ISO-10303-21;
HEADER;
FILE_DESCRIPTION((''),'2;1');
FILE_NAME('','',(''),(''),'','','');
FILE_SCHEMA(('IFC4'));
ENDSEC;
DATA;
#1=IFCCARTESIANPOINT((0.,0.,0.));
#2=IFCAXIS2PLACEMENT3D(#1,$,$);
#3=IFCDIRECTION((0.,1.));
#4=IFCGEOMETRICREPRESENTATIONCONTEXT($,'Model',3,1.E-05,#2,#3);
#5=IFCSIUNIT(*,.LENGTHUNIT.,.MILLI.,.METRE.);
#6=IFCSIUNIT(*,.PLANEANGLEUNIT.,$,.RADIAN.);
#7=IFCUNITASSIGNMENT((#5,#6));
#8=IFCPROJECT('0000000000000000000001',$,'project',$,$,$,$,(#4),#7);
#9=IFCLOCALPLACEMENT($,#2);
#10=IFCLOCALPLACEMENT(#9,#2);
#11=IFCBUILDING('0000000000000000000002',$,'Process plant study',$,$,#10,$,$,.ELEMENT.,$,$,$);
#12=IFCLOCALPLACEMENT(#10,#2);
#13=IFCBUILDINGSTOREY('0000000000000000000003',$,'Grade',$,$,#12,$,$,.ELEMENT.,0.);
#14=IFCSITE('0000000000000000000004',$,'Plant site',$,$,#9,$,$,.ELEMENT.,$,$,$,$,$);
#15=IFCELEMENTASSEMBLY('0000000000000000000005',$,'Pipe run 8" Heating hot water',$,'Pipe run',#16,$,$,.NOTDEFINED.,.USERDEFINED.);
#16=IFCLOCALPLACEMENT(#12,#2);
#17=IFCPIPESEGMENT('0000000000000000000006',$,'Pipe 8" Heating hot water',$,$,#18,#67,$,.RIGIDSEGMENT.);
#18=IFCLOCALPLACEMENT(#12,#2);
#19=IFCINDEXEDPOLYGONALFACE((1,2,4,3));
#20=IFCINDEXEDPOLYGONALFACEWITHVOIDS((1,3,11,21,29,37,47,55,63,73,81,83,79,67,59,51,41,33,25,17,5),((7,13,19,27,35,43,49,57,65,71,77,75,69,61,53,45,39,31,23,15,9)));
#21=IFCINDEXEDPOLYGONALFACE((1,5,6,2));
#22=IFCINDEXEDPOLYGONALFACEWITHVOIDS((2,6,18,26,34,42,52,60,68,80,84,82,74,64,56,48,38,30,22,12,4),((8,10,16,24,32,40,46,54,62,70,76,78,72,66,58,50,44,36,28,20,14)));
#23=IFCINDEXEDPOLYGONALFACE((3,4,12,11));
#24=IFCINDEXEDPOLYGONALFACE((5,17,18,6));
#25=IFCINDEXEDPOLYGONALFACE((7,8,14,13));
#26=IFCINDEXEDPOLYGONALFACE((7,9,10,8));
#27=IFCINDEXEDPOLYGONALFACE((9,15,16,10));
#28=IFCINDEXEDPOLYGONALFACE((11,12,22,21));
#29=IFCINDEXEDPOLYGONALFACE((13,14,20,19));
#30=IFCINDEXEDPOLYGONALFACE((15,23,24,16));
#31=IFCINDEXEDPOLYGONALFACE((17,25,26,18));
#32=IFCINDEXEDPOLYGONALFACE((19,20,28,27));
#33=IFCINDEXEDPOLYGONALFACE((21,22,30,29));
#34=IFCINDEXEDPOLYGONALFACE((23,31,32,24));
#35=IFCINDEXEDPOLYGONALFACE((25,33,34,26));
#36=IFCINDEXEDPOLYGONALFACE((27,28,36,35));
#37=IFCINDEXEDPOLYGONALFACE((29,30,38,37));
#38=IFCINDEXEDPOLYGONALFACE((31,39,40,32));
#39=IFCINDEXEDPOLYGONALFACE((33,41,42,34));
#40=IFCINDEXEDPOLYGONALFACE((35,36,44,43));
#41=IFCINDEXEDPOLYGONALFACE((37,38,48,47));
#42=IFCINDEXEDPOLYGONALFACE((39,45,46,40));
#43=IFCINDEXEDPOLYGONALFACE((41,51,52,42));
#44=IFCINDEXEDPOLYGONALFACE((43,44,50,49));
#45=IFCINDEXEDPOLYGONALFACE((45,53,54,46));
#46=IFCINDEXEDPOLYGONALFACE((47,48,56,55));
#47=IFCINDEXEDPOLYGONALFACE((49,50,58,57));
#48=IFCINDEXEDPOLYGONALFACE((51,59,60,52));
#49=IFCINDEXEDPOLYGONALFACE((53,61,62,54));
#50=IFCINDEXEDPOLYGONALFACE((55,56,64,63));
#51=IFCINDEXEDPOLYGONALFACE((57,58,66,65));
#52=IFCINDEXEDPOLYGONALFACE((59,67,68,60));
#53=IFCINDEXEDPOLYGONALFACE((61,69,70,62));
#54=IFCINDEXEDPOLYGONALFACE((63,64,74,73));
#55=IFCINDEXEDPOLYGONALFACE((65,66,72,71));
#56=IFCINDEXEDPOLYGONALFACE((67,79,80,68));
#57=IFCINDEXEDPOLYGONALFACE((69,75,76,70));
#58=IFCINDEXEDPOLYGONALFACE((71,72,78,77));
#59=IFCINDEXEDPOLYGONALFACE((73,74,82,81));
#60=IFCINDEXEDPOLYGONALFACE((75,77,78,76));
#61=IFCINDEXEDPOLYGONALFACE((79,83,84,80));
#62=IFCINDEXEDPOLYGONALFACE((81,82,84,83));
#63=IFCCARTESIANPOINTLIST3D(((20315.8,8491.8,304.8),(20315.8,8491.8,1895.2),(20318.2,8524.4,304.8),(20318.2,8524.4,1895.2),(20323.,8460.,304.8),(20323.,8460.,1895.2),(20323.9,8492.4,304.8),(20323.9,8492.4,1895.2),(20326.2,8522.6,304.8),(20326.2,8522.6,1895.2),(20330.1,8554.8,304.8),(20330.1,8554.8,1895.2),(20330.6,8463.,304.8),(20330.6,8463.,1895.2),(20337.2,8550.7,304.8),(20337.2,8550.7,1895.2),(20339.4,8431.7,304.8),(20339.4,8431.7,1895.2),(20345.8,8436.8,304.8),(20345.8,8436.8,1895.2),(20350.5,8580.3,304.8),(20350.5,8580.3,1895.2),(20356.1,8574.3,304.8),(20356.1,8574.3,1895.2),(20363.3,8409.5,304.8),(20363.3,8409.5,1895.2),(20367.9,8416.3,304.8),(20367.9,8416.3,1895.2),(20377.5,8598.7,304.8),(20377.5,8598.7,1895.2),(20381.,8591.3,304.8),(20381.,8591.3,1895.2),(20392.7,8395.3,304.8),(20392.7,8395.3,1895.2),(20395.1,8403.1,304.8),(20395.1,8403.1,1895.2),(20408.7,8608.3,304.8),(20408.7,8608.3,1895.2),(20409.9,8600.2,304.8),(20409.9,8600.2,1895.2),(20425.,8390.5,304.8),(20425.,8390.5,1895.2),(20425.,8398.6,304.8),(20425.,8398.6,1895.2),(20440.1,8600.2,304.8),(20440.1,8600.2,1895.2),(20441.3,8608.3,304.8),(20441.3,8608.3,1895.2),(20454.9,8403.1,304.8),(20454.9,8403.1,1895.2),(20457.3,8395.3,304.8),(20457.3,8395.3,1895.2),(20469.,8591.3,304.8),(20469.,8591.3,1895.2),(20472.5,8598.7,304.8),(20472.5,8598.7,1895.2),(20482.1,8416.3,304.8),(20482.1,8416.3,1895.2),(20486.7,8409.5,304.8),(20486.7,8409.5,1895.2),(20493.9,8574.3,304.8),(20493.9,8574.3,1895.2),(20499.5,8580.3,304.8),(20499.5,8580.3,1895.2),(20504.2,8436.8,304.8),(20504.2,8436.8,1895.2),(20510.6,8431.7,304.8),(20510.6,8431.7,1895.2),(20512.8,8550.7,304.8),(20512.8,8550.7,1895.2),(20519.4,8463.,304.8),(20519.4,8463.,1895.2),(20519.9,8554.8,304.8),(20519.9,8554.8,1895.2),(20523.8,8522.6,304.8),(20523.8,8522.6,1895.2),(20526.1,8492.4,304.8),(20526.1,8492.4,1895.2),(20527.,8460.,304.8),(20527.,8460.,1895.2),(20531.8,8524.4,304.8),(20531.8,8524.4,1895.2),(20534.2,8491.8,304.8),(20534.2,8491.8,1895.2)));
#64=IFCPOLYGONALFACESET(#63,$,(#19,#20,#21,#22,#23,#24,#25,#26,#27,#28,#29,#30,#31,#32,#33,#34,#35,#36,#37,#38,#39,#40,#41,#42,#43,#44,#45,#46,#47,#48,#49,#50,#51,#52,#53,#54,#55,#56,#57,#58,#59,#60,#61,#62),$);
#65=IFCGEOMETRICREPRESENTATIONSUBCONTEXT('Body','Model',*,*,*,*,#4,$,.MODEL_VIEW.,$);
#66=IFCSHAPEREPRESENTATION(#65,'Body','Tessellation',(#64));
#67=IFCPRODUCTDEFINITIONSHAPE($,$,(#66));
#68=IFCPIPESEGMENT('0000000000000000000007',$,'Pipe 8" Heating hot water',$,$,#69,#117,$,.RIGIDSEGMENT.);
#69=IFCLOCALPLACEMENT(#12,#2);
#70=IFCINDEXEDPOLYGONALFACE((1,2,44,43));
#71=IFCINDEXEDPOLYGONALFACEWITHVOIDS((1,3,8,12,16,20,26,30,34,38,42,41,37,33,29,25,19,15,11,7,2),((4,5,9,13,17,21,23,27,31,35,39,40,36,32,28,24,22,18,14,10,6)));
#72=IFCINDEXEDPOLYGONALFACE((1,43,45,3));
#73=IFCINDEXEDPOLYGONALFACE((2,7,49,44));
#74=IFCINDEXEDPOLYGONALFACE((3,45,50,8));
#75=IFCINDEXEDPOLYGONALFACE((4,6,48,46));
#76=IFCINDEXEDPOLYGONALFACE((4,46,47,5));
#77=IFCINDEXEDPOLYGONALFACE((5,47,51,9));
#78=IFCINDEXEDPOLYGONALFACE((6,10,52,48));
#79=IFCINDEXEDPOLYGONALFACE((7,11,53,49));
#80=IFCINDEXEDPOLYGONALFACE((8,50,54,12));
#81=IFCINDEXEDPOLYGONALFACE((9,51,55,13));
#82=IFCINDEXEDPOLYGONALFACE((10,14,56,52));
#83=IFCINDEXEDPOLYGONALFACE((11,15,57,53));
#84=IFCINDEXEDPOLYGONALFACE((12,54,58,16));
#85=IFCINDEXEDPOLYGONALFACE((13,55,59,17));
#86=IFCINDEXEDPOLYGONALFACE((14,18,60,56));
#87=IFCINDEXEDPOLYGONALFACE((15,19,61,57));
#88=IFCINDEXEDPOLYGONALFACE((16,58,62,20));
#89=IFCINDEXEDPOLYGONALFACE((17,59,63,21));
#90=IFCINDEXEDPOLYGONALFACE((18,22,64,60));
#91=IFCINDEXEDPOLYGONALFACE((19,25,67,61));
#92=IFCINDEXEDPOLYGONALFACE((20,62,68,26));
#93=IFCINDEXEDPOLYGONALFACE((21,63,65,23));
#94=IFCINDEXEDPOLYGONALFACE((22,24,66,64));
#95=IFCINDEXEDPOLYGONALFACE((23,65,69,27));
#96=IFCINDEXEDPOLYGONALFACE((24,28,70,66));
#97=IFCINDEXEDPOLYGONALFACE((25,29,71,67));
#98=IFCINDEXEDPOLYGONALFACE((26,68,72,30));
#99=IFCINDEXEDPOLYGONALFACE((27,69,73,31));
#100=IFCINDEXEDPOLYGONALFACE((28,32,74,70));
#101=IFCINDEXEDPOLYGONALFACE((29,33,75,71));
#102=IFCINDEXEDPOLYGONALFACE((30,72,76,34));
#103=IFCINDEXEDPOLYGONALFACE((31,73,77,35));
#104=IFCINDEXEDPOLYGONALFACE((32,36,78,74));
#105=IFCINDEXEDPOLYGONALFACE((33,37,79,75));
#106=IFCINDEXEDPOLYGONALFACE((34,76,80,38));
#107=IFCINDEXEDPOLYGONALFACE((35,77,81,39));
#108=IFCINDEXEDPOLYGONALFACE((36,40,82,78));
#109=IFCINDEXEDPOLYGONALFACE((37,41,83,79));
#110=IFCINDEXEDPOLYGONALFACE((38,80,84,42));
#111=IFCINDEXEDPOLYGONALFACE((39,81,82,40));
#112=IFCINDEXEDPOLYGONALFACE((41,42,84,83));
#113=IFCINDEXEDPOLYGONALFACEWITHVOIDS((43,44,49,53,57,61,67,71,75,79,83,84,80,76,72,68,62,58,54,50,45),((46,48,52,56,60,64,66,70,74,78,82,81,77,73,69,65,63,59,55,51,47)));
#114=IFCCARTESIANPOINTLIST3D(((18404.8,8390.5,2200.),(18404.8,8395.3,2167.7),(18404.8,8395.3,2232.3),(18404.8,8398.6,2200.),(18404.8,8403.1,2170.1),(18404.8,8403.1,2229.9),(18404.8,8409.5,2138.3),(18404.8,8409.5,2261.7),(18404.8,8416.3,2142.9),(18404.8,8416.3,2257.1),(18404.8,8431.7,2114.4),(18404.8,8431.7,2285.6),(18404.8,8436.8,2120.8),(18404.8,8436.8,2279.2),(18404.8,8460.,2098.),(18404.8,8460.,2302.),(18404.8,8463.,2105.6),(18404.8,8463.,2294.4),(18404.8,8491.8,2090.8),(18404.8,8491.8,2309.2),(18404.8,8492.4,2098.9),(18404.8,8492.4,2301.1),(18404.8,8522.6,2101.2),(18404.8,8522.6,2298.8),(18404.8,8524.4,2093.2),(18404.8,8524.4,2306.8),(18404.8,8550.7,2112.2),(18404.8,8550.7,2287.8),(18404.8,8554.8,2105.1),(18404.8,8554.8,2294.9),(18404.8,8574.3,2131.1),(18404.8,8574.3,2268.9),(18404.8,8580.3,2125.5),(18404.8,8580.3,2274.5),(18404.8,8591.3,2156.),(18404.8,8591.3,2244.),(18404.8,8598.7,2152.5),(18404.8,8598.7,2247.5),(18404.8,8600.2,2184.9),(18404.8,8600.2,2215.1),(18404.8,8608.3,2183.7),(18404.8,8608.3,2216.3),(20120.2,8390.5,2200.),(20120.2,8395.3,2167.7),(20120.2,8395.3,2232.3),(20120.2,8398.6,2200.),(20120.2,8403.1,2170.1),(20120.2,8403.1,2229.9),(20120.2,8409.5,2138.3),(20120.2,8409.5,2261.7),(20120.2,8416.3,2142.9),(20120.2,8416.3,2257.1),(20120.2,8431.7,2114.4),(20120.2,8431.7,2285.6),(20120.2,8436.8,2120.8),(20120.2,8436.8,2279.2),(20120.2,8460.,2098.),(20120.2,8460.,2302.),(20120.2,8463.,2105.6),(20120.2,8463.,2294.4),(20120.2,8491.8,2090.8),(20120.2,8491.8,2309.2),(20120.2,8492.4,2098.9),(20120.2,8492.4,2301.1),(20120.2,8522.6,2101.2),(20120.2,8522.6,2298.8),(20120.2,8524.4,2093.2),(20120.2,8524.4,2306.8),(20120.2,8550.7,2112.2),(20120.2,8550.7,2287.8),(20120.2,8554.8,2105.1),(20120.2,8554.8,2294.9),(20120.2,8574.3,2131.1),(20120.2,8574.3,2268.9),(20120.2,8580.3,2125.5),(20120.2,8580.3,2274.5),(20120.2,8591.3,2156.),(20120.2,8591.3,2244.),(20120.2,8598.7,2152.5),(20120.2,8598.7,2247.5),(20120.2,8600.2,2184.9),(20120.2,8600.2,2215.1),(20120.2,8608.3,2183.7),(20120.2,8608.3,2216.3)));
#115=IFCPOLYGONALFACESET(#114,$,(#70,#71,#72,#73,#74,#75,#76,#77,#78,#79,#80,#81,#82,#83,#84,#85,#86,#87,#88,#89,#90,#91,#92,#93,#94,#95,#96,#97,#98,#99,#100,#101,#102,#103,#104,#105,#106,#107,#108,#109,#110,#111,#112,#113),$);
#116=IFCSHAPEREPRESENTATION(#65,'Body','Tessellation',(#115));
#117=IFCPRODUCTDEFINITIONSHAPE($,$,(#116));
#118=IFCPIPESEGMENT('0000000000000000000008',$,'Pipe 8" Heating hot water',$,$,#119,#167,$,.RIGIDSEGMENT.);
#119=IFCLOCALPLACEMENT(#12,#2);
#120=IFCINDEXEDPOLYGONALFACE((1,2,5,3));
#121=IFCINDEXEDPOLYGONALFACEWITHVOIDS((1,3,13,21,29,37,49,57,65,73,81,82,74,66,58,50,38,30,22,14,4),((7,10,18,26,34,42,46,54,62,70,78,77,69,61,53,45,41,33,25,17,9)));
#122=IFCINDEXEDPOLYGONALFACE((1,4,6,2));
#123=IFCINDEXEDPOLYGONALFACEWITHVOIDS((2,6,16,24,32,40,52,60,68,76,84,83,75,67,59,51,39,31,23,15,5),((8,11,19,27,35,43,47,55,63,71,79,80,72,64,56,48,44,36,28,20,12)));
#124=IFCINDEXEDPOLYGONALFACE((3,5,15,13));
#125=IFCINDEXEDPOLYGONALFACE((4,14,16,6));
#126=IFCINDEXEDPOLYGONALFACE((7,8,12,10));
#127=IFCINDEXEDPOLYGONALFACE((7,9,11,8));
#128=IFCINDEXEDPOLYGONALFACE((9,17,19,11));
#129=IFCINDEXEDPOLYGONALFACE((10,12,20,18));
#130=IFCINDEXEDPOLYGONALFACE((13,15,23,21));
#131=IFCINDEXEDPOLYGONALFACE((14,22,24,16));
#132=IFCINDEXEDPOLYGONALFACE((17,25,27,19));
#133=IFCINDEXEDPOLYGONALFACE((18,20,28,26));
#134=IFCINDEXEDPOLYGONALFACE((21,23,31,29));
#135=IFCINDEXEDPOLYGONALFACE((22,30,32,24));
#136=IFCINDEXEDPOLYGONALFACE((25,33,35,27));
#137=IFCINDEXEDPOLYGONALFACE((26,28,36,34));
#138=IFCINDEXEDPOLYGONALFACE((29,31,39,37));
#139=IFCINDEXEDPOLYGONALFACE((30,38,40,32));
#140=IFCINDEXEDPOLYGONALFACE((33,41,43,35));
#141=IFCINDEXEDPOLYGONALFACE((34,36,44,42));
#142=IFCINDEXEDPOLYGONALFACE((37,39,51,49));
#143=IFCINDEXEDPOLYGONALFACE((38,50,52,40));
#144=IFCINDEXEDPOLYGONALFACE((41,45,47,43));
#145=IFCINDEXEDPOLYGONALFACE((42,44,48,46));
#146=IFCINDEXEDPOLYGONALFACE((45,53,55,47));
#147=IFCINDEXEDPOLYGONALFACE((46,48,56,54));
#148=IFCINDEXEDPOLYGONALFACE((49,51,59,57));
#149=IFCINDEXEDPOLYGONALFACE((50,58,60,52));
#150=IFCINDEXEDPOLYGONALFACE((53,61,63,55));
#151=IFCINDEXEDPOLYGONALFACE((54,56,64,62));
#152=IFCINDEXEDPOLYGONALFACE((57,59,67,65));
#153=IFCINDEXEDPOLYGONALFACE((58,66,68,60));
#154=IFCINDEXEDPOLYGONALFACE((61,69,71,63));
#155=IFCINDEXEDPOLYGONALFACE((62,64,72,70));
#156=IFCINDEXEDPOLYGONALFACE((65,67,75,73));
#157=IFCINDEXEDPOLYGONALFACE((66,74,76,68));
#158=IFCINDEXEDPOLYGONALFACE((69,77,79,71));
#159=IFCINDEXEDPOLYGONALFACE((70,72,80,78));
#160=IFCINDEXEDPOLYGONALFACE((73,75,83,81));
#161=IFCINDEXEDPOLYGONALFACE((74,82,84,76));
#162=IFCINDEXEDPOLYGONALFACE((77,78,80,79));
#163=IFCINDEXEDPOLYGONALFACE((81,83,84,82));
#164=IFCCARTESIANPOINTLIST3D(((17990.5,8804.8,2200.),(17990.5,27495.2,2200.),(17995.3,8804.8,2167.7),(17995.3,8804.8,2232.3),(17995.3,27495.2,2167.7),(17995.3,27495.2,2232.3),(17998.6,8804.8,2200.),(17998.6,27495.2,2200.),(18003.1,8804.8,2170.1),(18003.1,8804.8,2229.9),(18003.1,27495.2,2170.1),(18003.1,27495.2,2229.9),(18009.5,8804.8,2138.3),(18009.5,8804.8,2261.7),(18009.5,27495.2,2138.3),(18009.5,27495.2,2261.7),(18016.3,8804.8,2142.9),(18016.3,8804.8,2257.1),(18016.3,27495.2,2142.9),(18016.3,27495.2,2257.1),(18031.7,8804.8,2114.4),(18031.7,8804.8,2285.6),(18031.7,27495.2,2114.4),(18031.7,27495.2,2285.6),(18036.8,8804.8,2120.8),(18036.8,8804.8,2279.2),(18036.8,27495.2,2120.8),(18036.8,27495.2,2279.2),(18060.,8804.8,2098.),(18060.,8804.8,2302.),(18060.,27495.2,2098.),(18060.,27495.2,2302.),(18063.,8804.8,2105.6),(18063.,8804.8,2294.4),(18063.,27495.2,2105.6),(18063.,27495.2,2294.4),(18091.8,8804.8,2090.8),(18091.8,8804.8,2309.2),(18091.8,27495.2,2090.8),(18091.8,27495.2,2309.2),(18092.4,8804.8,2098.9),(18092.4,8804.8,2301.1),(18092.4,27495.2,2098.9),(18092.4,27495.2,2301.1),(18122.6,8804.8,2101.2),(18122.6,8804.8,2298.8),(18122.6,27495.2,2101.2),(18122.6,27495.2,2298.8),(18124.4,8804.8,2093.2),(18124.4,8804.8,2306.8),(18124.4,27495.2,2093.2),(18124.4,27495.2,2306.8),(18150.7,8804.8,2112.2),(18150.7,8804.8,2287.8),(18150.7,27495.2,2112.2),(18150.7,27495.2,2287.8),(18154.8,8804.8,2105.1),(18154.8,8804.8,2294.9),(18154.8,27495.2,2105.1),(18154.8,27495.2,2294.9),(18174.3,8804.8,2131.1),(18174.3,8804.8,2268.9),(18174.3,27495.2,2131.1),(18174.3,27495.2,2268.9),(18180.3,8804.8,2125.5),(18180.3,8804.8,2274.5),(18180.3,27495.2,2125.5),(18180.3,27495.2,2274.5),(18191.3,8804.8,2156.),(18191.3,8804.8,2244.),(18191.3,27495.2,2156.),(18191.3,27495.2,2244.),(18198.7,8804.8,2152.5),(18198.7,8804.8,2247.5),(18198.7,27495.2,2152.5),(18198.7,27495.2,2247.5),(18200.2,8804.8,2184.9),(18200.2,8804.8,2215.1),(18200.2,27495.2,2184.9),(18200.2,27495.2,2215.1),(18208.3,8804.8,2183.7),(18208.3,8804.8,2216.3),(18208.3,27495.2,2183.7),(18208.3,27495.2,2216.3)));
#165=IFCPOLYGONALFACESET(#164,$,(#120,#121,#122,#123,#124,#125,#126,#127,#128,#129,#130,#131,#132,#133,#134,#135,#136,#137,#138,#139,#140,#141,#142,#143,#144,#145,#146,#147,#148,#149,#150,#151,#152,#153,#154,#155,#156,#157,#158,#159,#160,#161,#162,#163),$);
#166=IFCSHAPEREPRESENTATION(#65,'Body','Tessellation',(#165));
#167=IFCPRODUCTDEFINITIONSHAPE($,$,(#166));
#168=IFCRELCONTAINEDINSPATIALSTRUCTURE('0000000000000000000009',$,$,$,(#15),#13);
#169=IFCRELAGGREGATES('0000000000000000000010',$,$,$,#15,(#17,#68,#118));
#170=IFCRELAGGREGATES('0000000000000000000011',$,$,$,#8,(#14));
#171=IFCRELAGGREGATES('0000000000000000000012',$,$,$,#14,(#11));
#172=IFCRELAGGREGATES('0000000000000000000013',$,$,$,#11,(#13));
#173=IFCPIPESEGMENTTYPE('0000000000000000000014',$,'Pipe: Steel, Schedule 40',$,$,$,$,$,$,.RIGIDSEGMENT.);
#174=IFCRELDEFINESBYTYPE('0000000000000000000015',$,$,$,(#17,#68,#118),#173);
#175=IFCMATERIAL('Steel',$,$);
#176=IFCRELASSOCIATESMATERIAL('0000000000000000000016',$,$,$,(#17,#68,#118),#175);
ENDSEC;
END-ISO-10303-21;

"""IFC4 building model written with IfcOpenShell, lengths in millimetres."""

from ifc_helpers import new_model, si_unit, direction, frame, origin, origin_with_axes, origin_2d, place, context, subcontext, project, spatial, hollow_circle, extrude, material, type_object, element, aggregate, save


model = new_model("IFC4")

# Units and contexts
model_context = context("Model", 3, precision=1e-05, world=origin(), true_north=direction((0.0, 1.0)))
body_context = subcontext(model_context, "Body", "Model", "MODEL_VIEW")
ifc_project = project(units=[si_unit("LENGTHUNIT", "METRE", prefix="MILLI"), si_unit("PLANEANGLEUNIT", "RADIAN")], contexts=[model_context])

# Site, building, storey
site_placement = place(None, origin())
site = spatial("IfcSite", under=ifc_project, at=site_placement, Name="Plant site", CompositionType="ELEMENT")
building_placement = place(site_placement, origin())
building = spatial("IfcBuilding", under=site, at=building_placement, Name="Process plant study", CompositionType="ELEMENT")
storey_placement = place(building_placement, origin())
storey = spatial("IfcBuildingStorey", under=building, at=storey_placement, Name="Grade", CompositionType="ELEMENT", Elevation=0.0)

# Element assembly, pipe segments
ifc_material = material(Name="Steel")
pipe_segment_type = type_object("IfcPipeSegmentType", Name="Pipe: Steel, Schedule 40", PredefinedType="RIGIDSEGMENT")
assembly_1_placement = place(storey_placement, origin_with_axes())
assembly_1 = element("IfcElementAssembly", 1, at=assembly_1_placement, inside=storey, Name="Pipe run 8\" Heating hot water", ObjectType="Pipe run", AssemblyPlace="NOTDEFINED", PredefinedType="USERDEFINED")
pipe_segment_1_placement = place(storey_placement, origin_with_axes())
pipe_segment_1 = element("IfcPipeSegment", 2, at=pipe_segment_1_placement, type_object=pipe_segment_type, material=ifc_material, Name="Pipe 8\" Heating hot water", PredefinedType="RIGIDSEGMENT", context=body_context, shape_type="SweptSolid", body=[
    extrude(hollow_circle(Radius=109.5, WallThickness=8.2, at=origin_2d()), frame((20425.0, 8500.0, 304.8), z_axis=(0.0, 0.0, 1.0), x_axis=(0.0, -1.0, 0.0)), (0.0, 0.0, 1.0), 1590.4),
])
pipe_segment_2_placement = place(storey_placement, origin_with_axes())
pipe_segment_2 = element("IfcPipeSegment", 3, at=pipe_segment_2_placement, type_object=pipe_segment_type, material=ifc_material, Name="Pipe 8\" Heating hot water", PredefinedType="RIGIDSEGMENT", context=body_context, shape_type="SweptSolid", body=[
    extrude(hollow_circle(Radius=109.5, WallThickness=8.2, at=origin_2d()), frame((20120.2, 8500.0, 2200.0), z_axis=(-1.0, 0.0, 0.0), x_axis=(0.0, -1.0, 0.0)), (0.0, 0.0, 1.0), 1715.4),
])
pipe_segment_3_placement = place(storey_placement, origin_with_axes())
pipe_segment_3 = element("IfcPipeSegment", 4, at=pipe_segment_3_placement, type_object=pipe_segment_type, material=ifc_material, Name="Pipe 8\" Heating hot water", PredefinedType="RIGIDSEGMENT", context=body_context, shape_type="SweptSolid", body=[
    extrude(hollow_circle(Radius=109.5, WallThickness=8.2, at=origin_2d()), frame((18100.0, 8804.8, 2200.0), z_axis=(0.0, 1.0, 0.0), x_axis=(-1.0, 0.0, 0.0)), (0.0, 0.0, 1.0), 18690.4),
])

aggregate(assembly_1, [pipe_segment_1, pipe_segment_2, pipe_segment_3])

save(model, "model.ifc")
